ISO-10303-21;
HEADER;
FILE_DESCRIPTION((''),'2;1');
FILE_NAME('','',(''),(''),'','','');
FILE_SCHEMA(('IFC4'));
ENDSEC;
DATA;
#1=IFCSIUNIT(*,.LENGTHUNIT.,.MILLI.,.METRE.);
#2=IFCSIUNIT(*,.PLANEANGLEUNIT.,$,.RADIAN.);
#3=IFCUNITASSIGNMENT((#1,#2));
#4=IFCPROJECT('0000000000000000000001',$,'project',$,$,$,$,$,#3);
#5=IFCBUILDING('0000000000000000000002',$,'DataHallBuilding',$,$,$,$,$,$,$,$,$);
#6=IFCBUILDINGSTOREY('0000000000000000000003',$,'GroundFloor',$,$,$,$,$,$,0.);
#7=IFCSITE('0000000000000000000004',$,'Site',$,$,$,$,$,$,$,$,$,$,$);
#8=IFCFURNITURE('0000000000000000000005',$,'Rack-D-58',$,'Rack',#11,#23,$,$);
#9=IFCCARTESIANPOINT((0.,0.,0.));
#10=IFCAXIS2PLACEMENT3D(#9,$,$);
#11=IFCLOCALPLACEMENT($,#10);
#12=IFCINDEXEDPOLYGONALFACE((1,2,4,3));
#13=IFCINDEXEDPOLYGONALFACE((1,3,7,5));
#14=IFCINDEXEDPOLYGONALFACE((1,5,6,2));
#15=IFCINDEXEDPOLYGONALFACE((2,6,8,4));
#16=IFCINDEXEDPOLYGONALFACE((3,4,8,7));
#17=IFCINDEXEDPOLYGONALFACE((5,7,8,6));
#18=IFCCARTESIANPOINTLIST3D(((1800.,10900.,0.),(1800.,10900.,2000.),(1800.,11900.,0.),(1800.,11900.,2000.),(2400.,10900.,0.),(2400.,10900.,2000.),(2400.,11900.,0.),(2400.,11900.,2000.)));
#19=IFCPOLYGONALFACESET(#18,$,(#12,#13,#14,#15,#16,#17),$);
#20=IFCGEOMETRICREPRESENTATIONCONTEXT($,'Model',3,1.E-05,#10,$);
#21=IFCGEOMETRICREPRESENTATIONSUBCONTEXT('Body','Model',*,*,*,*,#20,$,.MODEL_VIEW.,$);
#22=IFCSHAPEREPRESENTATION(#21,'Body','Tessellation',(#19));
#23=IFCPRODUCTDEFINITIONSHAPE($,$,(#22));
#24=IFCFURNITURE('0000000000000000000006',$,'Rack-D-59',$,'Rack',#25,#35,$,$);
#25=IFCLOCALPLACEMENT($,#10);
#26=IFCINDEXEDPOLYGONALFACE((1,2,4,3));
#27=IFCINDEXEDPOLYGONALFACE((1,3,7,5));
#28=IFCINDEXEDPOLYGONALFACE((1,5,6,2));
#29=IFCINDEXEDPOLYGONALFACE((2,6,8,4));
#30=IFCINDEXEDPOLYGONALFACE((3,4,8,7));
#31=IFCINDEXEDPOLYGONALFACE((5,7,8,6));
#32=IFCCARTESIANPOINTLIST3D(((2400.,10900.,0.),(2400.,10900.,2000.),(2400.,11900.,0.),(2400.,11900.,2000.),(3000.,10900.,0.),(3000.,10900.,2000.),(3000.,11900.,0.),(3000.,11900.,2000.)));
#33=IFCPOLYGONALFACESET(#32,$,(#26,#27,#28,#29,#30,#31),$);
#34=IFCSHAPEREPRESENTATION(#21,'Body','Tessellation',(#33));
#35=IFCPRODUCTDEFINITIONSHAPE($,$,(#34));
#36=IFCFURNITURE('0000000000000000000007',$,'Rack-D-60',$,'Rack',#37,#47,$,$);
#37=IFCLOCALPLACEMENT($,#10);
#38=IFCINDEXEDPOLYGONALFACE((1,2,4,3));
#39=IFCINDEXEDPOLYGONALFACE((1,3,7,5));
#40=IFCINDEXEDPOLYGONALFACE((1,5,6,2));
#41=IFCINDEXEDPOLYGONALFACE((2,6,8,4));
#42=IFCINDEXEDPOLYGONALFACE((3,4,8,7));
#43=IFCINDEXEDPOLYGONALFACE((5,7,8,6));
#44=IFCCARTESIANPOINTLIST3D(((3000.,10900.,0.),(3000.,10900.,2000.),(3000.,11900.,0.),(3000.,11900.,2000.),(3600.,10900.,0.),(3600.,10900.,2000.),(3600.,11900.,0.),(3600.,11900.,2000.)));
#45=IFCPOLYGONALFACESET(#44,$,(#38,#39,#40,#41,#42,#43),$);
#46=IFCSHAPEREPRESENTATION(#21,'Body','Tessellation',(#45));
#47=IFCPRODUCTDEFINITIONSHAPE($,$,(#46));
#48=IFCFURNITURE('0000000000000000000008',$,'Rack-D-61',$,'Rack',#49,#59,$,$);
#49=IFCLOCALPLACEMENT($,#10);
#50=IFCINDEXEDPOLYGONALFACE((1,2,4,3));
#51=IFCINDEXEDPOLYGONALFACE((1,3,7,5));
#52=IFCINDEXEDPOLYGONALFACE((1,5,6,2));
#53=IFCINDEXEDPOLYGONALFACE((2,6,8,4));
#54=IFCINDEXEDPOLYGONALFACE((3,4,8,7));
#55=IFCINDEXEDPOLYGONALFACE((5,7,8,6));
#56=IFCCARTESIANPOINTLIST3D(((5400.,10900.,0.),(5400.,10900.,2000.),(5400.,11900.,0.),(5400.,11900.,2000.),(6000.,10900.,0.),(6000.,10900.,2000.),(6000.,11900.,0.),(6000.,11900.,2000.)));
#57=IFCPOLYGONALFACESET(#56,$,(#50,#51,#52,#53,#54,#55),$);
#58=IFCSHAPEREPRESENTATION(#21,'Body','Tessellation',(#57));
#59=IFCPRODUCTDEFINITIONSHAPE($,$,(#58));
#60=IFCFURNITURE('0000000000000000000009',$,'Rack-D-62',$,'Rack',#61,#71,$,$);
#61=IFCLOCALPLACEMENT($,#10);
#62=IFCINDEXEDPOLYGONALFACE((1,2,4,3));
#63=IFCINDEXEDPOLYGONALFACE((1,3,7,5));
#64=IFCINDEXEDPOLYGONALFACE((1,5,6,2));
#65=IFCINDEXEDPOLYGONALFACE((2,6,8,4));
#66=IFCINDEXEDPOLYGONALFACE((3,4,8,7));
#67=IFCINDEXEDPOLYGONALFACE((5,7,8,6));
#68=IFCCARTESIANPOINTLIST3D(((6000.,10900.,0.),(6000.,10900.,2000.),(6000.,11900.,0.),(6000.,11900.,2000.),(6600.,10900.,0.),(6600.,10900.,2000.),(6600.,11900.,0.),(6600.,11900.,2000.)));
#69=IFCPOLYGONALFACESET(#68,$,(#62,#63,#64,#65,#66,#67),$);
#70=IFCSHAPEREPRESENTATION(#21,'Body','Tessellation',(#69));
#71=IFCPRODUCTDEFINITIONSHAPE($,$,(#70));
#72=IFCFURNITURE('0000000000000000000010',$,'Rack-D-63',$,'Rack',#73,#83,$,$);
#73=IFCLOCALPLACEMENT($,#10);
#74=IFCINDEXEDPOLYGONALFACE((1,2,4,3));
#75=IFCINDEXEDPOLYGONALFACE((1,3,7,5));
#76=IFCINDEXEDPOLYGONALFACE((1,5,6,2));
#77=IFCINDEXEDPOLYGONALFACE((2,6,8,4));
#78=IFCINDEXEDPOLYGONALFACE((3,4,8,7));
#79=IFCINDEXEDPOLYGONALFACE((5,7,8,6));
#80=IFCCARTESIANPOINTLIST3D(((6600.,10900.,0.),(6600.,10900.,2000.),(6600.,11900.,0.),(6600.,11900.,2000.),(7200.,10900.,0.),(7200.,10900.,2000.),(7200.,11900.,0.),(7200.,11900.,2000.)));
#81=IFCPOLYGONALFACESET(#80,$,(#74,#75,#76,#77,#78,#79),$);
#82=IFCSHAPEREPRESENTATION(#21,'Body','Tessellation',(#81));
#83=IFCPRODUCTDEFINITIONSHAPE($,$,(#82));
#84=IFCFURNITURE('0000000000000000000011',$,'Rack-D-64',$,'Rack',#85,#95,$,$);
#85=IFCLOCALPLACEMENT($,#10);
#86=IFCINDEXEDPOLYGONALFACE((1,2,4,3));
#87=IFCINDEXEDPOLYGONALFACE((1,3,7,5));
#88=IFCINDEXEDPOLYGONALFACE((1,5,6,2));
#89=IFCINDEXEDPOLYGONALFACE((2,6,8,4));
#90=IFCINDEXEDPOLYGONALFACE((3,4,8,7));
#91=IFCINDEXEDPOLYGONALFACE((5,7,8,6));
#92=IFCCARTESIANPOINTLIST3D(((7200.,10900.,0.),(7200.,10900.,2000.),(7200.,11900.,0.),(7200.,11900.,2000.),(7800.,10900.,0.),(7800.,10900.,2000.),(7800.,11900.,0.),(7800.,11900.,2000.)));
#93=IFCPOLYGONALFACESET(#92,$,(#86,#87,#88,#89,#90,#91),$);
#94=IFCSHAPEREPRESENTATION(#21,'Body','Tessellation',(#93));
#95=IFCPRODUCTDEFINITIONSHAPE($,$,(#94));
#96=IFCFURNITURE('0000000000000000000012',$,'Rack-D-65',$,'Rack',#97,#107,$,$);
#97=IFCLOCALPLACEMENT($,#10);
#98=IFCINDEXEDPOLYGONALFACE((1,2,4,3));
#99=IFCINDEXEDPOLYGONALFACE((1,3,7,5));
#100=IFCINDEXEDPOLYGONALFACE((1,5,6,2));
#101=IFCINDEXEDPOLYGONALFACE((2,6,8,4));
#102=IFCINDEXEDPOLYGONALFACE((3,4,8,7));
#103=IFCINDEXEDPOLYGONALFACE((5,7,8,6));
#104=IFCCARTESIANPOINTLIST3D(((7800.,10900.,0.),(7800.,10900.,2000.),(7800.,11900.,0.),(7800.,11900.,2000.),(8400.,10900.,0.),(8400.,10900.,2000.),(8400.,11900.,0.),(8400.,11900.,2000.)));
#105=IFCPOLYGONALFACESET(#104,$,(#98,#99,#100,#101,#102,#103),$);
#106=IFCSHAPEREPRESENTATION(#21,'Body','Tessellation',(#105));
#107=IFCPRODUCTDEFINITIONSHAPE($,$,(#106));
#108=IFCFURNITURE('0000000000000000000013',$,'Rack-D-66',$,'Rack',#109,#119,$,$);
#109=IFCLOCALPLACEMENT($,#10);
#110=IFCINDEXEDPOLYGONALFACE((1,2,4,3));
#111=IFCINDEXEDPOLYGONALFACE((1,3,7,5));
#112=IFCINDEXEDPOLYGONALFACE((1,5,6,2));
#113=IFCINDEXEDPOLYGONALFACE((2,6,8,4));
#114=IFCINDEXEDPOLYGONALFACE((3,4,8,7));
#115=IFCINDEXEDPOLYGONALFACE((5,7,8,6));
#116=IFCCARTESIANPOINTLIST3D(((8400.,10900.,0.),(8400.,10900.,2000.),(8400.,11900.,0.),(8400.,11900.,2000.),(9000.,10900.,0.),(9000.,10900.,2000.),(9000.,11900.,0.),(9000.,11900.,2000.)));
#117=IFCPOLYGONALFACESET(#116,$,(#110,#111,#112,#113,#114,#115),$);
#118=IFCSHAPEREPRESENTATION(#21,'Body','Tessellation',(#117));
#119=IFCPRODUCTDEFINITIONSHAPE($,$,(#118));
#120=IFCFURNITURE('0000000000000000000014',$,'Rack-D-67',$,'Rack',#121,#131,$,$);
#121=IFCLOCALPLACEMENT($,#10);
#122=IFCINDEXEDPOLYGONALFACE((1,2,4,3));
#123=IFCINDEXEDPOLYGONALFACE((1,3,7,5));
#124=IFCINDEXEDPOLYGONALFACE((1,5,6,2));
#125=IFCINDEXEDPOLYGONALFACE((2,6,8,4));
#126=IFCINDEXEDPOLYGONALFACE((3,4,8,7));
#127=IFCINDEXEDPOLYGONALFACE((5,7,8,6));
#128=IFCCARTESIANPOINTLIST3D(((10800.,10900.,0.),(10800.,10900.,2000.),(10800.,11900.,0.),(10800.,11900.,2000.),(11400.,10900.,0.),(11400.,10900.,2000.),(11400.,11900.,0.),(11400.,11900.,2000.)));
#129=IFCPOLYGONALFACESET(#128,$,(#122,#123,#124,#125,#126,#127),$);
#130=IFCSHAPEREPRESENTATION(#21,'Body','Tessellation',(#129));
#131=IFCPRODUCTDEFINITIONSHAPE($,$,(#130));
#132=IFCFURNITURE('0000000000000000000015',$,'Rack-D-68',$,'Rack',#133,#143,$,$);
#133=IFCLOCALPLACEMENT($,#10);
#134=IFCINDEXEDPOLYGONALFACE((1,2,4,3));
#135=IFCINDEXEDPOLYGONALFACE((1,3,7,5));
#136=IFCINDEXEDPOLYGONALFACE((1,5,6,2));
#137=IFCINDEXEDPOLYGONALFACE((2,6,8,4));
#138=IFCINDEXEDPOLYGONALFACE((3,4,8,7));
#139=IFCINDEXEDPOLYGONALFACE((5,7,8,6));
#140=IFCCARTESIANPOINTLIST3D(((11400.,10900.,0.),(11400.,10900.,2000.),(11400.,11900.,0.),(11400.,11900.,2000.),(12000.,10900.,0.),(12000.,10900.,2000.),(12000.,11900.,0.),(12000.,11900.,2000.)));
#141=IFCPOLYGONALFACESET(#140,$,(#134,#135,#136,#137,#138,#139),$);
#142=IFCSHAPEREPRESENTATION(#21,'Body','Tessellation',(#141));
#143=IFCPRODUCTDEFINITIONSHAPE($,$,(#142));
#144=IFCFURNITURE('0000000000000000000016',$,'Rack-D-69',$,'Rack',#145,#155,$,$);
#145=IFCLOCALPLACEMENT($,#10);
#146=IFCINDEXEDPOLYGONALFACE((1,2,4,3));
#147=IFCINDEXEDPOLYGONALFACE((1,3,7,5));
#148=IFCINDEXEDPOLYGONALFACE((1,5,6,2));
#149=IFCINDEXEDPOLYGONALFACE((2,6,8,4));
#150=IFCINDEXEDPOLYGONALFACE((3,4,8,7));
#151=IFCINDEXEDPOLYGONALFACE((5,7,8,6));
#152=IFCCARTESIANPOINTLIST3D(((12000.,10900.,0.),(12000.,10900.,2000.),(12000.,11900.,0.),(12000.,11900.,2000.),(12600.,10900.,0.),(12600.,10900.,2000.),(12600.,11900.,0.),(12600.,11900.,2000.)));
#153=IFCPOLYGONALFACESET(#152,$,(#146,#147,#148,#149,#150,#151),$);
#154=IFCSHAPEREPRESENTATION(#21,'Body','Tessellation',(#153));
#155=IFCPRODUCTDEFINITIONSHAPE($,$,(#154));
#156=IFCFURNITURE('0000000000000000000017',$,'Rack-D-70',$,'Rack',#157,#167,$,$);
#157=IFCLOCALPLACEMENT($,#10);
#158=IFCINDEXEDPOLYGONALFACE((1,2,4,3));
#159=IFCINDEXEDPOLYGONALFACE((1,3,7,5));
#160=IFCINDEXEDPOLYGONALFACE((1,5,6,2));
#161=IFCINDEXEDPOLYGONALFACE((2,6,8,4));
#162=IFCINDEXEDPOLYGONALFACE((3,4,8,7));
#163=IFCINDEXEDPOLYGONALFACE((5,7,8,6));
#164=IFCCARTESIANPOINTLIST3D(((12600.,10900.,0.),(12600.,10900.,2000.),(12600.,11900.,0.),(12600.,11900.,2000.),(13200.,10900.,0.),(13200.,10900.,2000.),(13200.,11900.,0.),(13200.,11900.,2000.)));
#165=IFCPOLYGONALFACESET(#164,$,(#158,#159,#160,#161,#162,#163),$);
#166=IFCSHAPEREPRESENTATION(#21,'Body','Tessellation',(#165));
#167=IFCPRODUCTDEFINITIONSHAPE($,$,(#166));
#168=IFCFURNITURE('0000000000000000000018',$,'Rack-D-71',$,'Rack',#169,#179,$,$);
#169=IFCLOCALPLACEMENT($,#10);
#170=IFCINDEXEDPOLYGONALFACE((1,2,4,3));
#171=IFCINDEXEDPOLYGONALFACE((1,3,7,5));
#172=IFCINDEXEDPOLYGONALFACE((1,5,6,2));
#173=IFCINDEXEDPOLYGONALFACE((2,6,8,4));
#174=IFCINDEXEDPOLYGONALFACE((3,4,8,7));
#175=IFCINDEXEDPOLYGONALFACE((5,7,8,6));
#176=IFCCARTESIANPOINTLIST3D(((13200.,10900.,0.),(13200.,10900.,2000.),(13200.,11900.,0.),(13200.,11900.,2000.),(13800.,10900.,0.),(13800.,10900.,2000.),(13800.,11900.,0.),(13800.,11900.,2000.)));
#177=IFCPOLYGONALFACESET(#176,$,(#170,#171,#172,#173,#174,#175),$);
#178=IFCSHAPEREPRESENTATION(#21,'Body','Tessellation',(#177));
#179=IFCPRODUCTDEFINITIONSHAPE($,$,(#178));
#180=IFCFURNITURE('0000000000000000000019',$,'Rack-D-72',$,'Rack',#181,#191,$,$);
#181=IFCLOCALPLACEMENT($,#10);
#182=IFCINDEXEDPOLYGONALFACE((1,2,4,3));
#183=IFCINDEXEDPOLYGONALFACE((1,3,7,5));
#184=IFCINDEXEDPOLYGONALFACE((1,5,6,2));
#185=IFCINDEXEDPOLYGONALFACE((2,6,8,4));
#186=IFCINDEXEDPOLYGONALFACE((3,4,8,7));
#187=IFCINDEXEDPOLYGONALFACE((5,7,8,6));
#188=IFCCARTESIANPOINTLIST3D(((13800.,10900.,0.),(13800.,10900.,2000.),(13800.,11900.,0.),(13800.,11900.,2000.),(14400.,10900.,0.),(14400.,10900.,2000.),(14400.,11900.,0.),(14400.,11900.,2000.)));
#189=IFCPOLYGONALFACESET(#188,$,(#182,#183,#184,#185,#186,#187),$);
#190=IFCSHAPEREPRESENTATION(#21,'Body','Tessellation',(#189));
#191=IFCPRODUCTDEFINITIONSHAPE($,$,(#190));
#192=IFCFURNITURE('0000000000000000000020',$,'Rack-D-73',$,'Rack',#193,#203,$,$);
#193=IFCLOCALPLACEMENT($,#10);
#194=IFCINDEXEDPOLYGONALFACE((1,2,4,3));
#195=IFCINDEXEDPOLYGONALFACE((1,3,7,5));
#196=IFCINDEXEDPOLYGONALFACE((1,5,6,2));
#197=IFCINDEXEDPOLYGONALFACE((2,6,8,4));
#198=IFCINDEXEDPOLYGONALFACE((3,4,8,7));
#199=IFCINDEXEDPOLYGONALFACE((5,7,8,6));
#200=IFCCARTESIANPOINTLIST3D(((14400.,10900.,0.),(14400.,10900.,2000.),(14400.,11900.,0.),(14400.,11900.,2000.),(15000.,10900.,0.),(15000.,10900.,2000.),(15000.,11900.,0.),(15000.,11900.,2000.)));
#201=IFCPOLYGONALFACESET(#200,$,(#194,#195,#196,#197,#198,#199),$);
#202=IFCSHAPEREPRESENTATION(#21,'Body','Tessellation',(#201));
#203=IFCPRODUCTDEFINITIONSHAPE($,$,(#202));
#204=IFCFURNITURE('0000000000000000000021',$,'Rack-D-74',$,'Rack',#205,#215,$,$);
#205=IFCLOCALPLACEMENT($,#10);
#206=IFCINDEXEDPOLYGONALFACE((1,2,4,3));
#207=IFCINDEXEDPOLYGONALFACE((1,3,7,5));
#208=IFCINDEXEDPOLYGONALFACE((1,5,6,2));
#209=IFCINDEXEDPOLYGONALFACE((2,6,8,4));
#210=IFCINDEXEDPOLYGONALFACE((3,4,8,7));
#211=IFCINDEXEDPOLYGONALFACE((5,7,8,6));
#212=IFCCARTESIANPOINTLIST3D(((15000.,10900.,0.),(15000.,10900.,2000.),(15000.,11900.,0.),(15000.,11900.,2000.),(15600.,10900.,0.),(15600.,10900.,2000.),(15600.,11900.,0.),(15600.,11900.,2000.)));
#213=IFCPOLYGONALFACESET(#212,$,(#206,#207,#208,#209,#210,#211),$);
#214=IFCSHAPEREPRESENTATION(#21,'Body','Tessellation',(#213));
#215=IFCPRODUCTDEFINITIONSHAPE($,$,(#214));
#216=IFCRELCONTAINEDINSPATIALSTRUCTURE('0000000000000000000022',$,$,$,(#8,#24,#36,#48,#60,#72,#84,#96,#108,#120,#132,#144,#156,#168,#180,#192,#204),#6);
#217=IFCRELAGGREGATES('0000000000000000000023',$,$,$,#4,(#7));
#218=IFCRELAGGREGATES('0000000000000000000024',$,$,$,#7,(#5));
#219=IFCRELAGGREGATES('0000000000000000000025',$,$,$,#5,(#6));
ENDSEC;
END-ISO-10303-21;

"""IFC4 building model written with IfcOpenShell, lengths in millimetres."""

from ifc_helpers import new_model, si_unit, frame, origin, place, context, subcontext, project, spatial, rectangle, extrude, element, save


model = new_model("IFC4")

# Units and contexts
model_context = context("Model", 3, precision=1e-05, world=origin())
body_context = subcontext(model_context, "Body", "Model", "MODEL_VIEW")
ifc_project = project(units=[si_unit("LENGTHUNIT", "METRE", prefix="MILLI"), si_unit("PLANEANGLEUNIT", "RADIAN")])

# Site, building, storey
site = spatial("IfcSite", under=ifc_project, Name="Site")
building = spatial("IfcBuilding", under=site, Name="DataHallBuilding")
storey = spatial("IfcBuildingStorey", under=building, Name="GroundFloor", Elevation=0.0)

# Furniture
furniture_1_placement = place(None, origin())
element("IfcFurniture", 1, at=furniture_1_placement, inside=storey, Name="Rack-D-58", ObjectType="Rack", context=body_context, shape_type="SweptSolid", body=[
    extrude(rectangle(XDim=600.0, YDim=1000.0), frame((2100.0, 11400.0, 0.0), z_axis=(0.0, 0.0, 1.0), x_axis=(1.0, 0.0, 0.0)), (0.0, 0.0, 1.0), 2000.0),
])
furniture_2_placement = place(None, origin())
element("IfcFurniture", 2, at=furniture_2_placement, inside=storey, Name="Rack-D-59", ObjectType="Rack", context=body_context, shape_type="SweptSolid", body=[
    extrude(rectangle(XDim=600.0, YDim=1000.0), frame((2700.0, 11400.0, 0.0), z_axis=(0.0, 0.0, 1.0), x_axis=(1.0, 0.0, 0.0)), (0.0, 0.0, 1.0), 2000.0),
])
furniture_3_placement = place(None, origin())
element("IfcFurniture", 3, at=furniture_3_placement, inside=storey, Name="Rack-D-60", ObjectType="Rack", context=body_context, shape_type="SweptSolid", body=[
    extrude(rectangle(XDim=600.0, YDim=1000.0), frame((3300.0, 11400.0, 0.0), z_axis=(0.0, 0.0, 1.0), x_axis=(1.0, 0.0, 0.0)), (0.0, 0.0, 1.0), 2000.0),
])
furniture_4_placement = place(None, origin())
element("IfcFurniture", 4, at=furniture_4_placement, inside=storey, Name="Rack-D-61", ObjectType="Rack", context=body_context, shape_type="SweptSolid", body=[
    extrude(rectangle(XDim=600.0, YDim=1000.0), frame((5700.0, 11400.0, 0.0), z_axis=(0.0, 0.0, 1.0), x_axis=(1.0, 0.0, 0.0)), (0.0, 0.0, 1.0), 2000.0),
])
furniture_5_placement = place(None, origin())
element("IfcFurniture", 5, at=furniture_5_placement, inside=storey, Name="Rack-D-62", ObjectType="Rack", context=body_context, shape_type="SweptSolid", body=[
    extrude(rectangle(XDim=600.0, YDim=1000.0), frame((6300.0, 11400.0, 0.0), z_axis=(0.0, 0.0, 1.0), x_axis=(1.0, 0.0, 0.0)), (0.0, 0.0, 1.0), 2000.0),
])
furniture_6_placement = place(None, origin())
element("IfcFurniture", 6, at=furniture_6_placement, inside=storey, Name="Rack-D-63", ObjectType="Rack", context=body_context, shape_type="SweptSolid", body=[
    extrude(rectangle(XDim=600.0, YDim=1000.0), frame((6900.0, 11400.0, 0.0), z_axis=(0.0, 0.0, 1.0), x_axis=(1.0, 0.0, 0.0)), (0.0, 0.0, 1.0), 2000.0),
])
furniture_7_placement = place(None, origin())
element("IfcFurniture", 7, at=furniture_7_placement, inside=storey, Name="Rack-D-64", ObjectType="Rack", context=body_context, shape_type="SweptSolid", body=[
    extrude(rectangle(XDim=600.0, YDim=1000.0), frame((7500.0, 11400.0, 0.0), z_axis=(0.0, 0.0, 1.0), x_axis=(1.0, 0.0, 0.0)), (0.0, 0.0, 1.0), 2000.0),
])
furniture_8_placement = place(None, origin())
element("IfcFurniture", 8, at=furniture_8_placement, inside=storey, Name="Rack-D-65", ObjectType="Rack", context=body_context, shape_type="SweptSolid", body=[
    extrude(rectangle(XDim=600.0, YDim=1000.0), frame((8100.0, 11400.0, 0.0), z_axis=(0.0, 0.0, 1.0), x_axis=(1.0, 0.0, 0.0)), (0.0, 0.0, 1.0), 2000.0),
])
furniture_9_placement = place(None, origin())
element("IfcFurniture", 9, at=furniture_9_placement, inside=storey, Name="Rack-D-66", ObjectType="Rack", context=body_context, shape_type="SweptSolid", body=[
    extrude(rectangle(XDim=600.0, YDim=1000.0), frame((8700.0, 11400.0, 0.0), z_axis=(0.0, 0.0, 1.0), x_axis=(1.0, 0.0, 0.0)), (0.0, 0.0, 1.0), 2000.0),
])
furniture_10_placement = place(None, origin())
element("IfcFurniture", 10, at=furniture_10_placement, inside=storey, Name="Rack-D-67", ObjectType="Rack", context=body_context, shape_type="SweptSolid", body=[
    extrude(rectangle(XDim=600.0, YDim=1000.0), frame((11100.0, 11400.0, 0.0), z_axis=(0.0, 0.0, 1.0), x_axis=(1.0, 0.0, 0.0)), (0.0, 0.0, 1.0), 2000.0),
])
furniture_11_placement = place(None, origin())
element("IfcFurniture", 11, at=furniture_11_placement, inside=storey, Name="Rack-D-68", ObjectType="Rack", context=body_context, shape_type="SweptSolid", body=[
    extrude(rectangle(XDim=600.0, YDim=1000.0), frame((11700.0, 11400.0, 0.0), z_axis=(0.0, 0.0, 1.0), x_axis=(1.0, 0.0, 0.0)), (0.0, 0.0, 1.0), 2000.0),
])
furniture_12_placement = place(None, origin())
element("IfcFurniture", 12, at=furniture_12_placement, inside=storey, Name="Rack-D-69", ObjectType="Rack", context=body_context, shape_type="SweptSolid", body=[
    extrude(rectangle(XDim=600.0, YDim=1000.0), frame((12300.0, 11400.0, 0.0), z_axis=(0.0, 0.0, 1.0), x_axis=(1.0, 0.0, 0.0)), (0.0, 0.0, 1.0), 2000.0),
])
furniture_13_placement = place(None, origin())
element("IfcFurniture", 13, at=furniture_13_placement, inside=storey, Name="Rack-D-70", ObjectType="Rack", context=body_context, shape_type="SweptSolid", body=[
    extrude(rectangle(XDim=600.0, YDim=1000.0), frame((12900.0, 11400.0, 0.0), z_axis=(0.0, 0.0, 1.0), x_axis=(1.0, 0.0, 0.0)), (0.0, 0.0, 1.0), 2000.0),
])
furniture_14_placement = place(None, origin())
element("IfcFurniture", 14, at=furniture_14_placement, inside=storey, Name="Rack-D-71", ObjectType="Rack", context=body_context, shape_type="SweptSolid", body=[
    extrude(rectangle(XDim=600.0, YDim=1000.0), frame((13500.0, 11400.0, 0.0), z_axis=(0.0, 0.0, 1.0), x_axis=(1.0, 0.0, 0.0)), (0.0, 0.0, 1.0), 2000.0),
])
furniture_15_placement = place(None, origin())
element("IfcFurniture", 15, at=furniture_15_placement, inside=storey, Name="Rack-D-72", ObjectType="Rack", context=body_context, shape_type="SweptSolid", body=[
    extrude(rectangle(XDim=600.0, YDim=1000.0), frame((14100.0, 11400.0, 0.0), z_axis=(0.0, 0.0, 1.0), x_axis=(1.0, 0.0, 0.0)), (0.0, 0.0, 1.0), 2000.0),
])
furniture_16_placement = place(None, origin())
element("IfcFurniture", 16, at=furniture_16_placement, inside=storey, Name="Rack-D-73", ObjectType="Rack", context=body_context, shape_type="SweptSolid", body=[
    extrude(rectangle(XDim=600.0, YDim=1000.0), frame((14700.0, 11400.0, 0.0), z_axis=(0.0, 0.0, 1.0), x_axis=(1.0, 0.0, 0.0)), (0.0, 0.0, 1.0), 2000.0),
])
furniture_17_placement = place(None, origin())
element("IfcFurniture", 17, at=furniture_17_placement, inside=storey, Name="Rack-D-74", ObjectType="Rack", context=body_context, shape_type="SweptSolid", body=[
    extrude(rectangle(XDim=600.0, YDim=1000.0), frame((15300.0, 11400.0, 0.0), z_axis=(0.0, 0.0, 1.0), x_axis=(1.0, 0.0, 0.0)), (0.0, 0.0, 1.0), 2000.0),
])

save(model, "model.ifc")
